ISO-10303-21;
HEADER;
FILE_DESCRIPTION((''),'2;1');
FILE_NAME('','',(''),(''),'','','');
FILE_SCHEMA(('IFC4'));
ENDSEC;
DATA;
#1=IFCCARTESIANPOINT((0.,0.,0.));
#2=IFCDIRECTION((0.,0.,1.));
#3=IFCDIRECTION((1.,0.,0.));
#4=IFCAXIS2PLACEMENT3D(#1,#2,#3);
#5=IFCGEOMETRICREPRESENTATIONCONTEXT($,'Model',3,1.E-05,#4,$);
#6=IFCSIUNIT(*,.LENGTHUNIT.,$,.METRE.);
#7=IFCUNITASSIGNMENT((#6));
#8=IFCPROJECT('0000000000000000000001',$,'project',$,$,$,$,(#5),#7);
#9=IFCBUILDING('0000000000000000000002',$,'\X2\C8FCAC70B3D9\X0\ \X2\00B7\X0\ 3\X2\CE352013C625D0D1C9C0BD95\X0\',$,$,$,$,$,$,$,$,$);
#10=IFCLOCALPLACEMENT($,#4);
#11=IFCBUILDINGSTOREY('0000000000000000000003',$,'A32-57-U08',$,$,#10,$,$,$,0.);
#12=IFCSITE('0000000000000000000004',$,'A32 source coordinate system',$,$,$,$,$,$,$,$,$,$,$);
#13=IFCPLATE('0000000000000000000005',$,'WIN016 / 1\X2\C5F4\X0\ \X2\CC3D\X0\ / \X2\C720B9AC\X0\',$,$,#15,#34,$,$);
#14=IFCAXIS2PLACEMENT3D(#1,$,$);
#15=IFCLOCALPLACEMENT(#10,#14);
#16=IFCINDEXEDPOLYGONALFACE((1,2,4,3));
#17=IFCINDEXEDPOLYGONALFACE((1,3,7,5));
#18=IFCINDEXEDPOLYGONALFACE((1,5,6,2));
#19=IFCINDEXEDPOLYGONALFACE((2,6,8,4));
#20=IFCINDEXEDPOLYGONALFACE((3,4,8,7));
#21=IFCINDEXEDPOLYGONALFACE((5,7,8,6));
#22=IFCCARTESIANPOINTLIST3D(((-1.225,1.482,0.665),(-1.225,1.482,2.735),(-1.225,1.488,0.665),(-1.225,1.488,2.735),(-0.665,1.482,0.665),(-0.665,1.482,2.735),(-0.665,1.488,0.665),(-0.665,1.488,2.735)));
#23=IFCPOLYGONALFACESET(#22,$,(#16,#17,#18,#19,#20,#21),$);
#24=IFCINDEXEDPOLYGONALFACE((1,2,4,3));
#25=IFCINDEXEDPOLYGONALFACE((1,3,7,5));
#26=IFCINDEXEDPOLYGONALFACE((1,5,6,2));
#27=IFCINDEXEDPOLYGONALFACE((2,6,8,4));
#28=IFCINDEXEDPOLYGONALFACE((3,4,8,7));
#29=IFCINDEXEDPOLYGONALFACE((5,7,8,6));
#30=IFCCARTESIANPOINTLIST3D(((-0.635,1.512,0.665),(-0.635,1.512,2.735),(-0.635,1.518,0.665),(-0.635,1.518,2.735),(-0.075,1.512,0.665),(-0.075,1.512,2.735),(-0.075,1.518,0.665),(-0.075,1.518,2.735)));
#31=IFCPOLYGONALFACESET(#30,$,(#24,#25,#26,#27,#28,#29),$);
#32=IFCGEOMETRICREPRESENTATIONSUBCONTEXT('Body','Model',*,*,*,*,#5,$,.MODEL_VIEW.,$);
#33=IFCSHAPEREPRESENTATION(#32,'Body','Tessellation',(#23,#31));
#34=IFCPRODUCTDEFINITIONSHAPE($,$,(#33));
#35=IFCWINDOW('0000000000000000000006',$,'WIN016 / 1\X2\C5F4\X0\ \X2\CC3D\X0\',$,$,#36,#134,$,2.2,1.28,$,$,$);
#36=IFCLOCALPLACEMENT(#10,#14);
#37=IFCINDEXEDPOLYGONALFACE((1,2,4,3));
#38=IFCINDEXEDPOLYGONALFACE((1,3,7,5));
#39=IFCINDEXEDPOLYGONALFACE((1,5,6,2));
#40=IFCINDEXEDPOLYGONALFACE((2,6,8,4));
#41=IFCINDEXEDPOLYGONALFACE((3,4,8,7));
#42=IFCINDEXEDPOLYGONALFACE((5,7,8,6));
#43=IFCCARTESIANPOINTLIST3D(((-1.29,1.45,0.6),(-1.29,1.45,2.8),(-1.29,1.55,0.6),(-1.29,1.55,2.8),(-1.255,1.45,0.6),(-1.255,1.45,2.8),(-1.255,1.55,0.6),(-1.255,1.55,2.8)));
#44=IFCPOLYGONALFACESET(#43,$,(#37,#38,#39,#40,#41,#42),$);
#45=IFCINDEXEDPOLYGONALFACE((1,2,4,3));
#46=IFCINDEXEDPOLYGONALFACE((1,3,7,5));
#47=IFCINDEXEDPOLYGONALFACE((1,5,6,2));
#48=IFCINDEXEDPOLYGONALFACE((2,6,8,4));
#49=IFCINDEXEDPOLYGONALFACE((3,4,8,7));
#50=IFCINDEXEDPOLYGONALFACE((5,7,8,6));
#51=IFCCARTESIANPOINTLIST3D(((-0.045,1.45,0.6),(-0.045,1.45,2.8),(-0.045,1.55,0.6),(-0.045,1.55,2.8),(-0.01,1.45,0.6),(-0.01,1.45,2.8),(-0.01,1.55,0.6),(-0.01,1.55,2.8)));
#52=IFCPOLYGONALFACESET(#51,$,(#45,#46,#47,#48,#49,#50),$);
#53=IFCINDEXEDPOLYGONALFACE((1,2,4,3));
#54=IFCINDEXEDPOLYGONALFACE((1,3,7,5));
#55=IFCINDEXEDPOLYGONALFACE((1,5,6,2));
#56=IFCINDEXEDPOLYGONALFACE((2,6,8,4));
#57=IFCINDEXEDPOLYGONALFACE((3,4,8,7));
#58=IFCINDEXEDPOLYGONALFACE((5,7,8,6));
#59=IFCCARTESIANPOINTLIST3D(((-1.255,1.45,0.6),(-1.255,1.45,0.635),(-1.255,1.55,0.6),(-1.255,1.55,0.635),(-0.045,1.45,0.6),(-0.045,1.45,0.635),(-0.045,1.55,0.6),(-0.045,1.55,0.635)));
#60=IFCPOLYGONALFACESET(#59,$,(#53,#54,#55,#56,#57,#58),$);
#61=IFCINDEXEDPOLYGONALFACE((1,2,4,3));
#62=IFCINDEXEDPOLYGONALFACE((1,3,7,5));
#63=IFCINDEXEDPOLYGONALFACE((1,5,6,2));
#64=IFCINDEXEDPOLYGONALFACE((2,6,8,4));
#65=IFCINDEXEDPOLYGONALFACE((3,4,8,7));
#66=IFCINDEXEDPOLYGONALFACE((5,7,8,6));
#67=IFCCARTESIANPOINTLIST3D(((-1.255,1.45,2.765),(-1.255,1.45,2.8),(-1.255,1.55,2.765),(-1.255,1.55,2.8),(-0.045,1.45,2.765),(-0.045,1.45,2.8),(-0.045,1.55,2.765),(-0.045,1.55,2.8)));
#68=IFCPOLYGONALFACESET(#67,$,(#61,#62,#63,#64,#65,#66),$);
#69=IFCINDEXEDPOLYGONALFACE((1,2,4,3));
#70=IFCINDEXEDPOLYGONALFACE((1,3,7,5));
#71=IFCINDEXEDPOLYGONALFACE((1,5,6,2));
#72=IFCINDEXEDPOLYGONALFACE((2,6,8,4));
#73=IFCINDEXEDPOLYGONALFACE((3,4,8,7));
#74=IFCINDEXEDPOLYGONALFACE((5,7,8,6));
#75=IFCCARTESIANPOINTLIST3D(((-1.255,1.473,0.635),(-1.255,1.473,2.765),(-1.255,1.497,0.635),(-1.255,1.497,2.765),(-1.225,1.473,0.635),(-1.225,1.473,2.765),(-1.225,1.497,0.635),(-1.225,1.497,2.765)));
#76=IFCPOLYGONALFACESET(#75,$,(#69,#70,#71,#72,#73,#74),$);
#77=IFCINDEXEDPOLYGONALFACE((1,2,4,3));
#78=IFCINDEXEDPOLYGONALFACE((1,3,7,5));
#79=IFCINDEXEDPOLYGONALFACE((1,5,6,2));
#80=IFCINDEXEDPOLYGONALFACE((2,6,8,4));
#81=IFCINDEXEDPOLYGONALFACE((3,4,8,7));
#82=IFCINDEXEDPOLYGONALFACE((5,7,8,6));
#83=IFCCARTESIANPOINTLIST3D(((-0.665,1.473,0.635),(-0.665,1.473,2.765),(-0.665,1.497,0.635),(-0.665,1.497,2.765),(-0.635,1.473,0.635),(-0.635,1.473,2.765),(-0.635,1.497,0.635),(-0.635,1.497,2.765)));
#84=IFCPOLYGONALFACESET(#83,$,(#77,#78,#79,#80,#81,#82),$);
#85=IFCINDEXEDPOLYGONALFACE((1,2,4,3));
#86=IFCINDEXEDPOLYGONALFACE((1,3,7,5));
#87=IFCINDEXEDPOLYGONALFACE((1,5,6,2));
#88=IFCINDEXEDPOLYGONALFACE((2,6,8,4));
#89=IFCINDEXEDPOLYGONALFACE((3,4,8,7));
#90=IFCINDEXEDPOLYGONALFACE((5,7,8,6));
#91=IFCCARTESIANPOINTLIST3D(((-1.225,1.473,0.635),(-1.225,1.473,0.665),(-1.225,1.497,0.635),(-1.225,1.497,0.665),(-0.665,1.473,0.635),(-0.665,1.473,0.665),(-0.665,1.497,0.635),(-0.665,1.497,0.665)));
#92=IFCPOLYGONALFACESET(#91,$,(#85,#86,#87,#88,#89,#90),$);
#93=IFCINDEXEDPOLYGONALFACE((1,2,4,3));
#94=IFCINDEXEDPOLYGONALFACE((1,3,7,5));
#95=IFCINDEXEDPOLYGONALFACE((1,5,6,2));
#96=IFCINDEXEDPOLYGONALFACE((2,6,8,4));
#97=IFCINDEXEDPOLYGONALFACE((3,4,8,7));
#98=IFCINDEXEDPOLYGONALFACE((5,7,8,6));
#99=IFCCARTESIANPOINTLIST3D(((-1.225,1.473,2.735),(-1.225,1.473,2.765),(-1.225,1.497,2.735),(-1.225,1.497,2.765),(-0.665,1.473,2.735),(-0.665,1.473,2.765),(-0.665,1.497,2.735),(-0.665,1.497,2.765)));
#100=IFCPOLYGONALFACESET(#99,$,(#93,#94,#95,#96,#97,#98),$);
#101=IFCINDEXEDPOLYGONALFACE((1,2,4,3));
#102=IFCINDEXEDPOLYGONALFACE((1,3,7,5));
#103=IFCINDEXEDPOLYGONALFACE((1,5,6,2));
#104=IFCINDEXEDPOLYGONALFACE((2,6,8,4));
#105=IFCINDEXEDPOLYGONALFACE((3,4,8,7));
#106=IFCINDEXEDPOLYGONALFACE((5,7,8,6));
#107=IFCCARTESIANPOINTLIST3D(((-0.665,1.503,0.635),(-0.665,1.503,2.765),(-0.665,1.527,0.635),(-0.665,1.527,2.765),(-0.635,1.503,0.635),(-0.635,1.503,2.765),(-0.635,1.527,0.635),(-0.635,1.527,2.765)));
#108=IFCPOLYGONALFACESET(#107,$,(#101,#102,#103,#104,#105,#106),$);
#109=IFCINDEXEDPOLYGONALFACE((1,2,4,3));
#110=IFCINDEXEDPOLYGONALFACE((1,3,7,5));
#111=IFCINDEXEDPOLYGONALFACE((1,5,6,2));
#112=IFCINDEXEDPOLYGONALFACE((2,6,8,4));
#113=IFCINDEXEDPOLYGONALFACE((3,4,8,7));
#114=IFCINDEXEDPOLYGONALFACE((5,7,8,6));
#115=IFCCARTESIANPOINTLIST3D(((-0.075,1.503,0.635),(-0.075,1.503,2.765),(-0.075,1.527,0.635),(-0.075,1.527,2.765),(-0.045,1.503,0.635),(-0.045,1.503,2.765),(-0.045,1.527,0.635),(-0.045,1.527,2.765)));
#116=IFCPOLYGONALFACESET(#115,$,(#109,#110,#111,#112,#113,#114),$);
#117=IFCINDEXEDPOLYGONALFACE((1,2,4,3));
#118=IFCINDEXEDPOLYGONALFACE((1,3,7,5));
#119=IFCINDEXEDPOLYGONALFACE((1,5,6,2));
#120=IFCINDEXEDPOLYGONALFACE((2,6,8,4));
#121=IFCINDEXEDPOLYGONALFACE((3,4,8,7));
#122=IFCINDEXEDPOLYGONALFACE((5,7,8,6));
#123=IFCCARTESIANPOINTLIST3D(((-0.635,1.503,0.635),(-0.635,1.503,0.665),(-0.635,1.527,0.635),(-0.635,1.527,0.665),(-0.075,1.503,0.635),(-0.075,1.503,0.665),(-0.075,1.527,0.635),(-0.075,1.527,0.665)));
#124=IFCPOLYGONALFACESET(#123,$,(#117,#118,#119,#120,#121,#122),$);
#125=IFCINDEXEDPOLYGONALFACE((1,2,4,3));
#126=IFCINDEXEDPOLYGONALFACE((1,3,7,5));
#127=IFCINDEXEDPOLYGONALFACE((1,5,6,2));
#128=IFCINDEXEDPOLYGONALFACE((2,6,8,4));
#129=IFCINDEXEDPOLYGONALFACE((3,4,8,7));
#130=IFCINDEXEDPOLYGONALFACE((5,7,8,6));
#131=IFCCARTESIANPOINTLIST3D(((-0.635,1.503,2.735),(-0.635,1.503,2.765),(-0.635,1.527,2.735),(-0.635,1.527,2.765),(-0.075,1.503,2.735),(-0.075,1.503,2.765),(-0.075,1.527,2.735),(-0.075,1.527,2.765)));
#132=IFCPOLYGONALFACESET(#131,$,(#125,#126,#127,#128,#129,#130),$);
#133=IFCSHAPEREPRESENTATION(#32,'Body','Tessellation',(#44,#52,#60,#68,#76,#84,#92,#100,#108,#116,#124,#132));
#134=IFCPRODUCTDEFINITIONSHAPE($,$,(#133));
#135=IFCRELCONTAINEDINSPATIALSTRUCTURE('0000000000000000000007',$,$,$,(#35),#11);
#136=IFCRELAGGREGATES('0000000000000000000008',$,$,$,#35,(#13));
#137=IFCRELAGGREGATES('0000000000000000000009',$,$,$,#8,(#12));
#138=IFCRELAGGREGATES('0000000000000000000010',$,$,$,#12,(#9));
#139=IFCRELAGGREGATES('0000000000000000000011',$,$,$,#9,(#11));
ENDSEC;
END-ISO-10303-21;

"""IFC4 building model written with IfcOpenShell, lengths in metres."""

from ifc_helpers import new_model, si_unit, frame, origin_with_axes, place, context, subcontext, project, spatial, polyline, outline, extrude, element, aggregate, save


model = new_model("IFC4")

# Units and contexts
model_context = context("Model", 3, precision=1e-05, world=origin_with_axes())
body_context = subcontext(model_context, "Body", "Model", "MODEL_VIEW")
ifc_project = project(units=[si_unit("LENGTHUNIT", "METRE")], contexts=[model_context])

# Plate
storey_placement = place(None, origin_with_axes())
window_1_placement = place(storey_placement, origin_with_axes())
plate_1_placement = place(window_1_placement, origin_with_axes())
plate_1 = element("IfcPlate", 1, at=plate_1_placement, Name="WIN016 / 1열 창 / 유리", context=body_context, shape_type="SweptSolid", body=[
    extrude(outline(polyline([(-1.225, 1.482), (-1.225, 1.488), (-0.665, 1.488), (-0.665, 1.482), (-1.225, 1.482)])), frame((0.0, 0.0, 0.665)), (0.0, 0.0, 1.0), 2.07),
    extrude(outline(polyline([(-0.635, 1.512), (-0.635, 1.518), (-0.075, 1.518), (-0.075, 1.512), (-0.635, 1.512)])), frame((0.0, 0.0, 0.665)), (0.0, 0.0, 1.0), 2.07),
])

# Site, building, storey
site = spatial("IfcSite", under=ifc_project, Name="A32 source coordinate system")
building = spatial("IfcBuilding", under=site, Name="주거동 · 3층–옥탑지붕")
storey = spatial("IfcBuildingStorey", under=building, at=storey_placement, Name="A32-57-U08", Elevation=0.0)

# Window
window_1 = element("IfcWindow", 2, at=window_1_placement, inside=storey, Name="WIN016 / 1열 창", OverallHeight=2.2, OverallWidth=1.28, context=body_context, shape_type="SweptSolid", body=[
    extrude(outline(polyline([(-1.29, 1.45), (-1.29, 1.55), (-1.255, 1.55), (-1.255, 1.45), (-1.29, 1.45)])), frame((0.0, 0.0, 0.6)), (0.0, 0.0, 1.0), 2.2),
    extrude(outline(polyline([(-0.045, 1.45), (-0.045, 1.55), (-0.01, 1.55), (-0.01, 1.45), (-0.045, 1.45)])), frame((0.0, 0.0, 0.6)), (0.0, 0.0, 1.0), 2.2),
    extrude(outline(polyline([(-1.255, 1.45), (-1.255, 1.55), (-0.045, 1.55), (-0.045, 1.45), (-1.255, 1.45)])), frame((0.0, 0.0, 0.6)), (0.0, 0.0, 1.0), 0.035),
    extrude(outline(polyline([(-1.255, 1.45), (-1.255, 1.55), (-0.045, 1.55), (-0.045, 1.45), (-1.255, 1.45)])), frame((0.0, 0.0, 2.765)), (0.0, 0.0, 1.0), 0.035),
    extrude(outline(polyline([(-1.255, 1.473), (-1.255, 1.497), (-1.225, 1.497), (-1.225, 1.473), (-1.255, 1.473)])), frame((0.0, 0.0, 0.635)), (0.0, 0.0, 1.0), 2.13),
    extrude(outline(polyline([(-0.665, 1.473), (-0.665, 1.497), (-0.635, 1.497), (-0.635, 1.473), (-0.665, 1.473)])), frame((0.0, 0.0, 0.635)), (0.0, 0.0, 1.0), 2.13),
    extrude(outline(polyline([(-1.225, 1.473), (-1.225, 1.497), (-0.665, 1.497), (-0.665, 1.473), (-1.225, 1.473)])), frame((0.0, 0.0, 0.635)), (0.0, 0.0, 1.0), 0.03),
    extrude(outline(polyline([(-1.225, 1.473), (-1.225, 1.497), (-0.665, 1.497), (-0.665, 1.473), (-1.225, 1.473)])), frame((0.0, 0.0, 2.735)), (0.0, 0.0, 1.0), 0.03),
    extrude(outline(polyline([(-0.665, 1.503), (-0.665, 1.527), (-0.635, 1.527), (-0.635, 1.503), (-0.665, 1.503)])), frame((0.0, 0.0, 0.635)), (0.0, 0.0, 1.0), 2.13),
    extrude(outline(polyline([(-0.075, 1.503), (-0.075, 1.527), (-0.045, 1.527), (-0.045, 1.503), (-0.075, 1.503)])), frame((0.0, 0.0, 0.635)), (0.0, 0.0, 1.0), 2.13),
    extrude(outline(polyline([(-0.635, 1.503), (-0.635, 1.527), (-0.075, 1.527), (-0.075, 1.503), (-0.635, 1.503)])), frame((0.0, 0.0, 0.635)), (0.0, 0.0, 1.0), 0.03),
    extrude(outline(polyline([(-0.635, 1.503), (-0.635, 1.527), (-0.075, 1.527), (-0.075, 1.503), (-0.635, 1.503)])), frame((0.0, 0.0, 2.735)), (0.0, 0.0, 1.0), 0.03),
])
aggregate(window_1, [plate_1])

save(model, "model.ifc")
